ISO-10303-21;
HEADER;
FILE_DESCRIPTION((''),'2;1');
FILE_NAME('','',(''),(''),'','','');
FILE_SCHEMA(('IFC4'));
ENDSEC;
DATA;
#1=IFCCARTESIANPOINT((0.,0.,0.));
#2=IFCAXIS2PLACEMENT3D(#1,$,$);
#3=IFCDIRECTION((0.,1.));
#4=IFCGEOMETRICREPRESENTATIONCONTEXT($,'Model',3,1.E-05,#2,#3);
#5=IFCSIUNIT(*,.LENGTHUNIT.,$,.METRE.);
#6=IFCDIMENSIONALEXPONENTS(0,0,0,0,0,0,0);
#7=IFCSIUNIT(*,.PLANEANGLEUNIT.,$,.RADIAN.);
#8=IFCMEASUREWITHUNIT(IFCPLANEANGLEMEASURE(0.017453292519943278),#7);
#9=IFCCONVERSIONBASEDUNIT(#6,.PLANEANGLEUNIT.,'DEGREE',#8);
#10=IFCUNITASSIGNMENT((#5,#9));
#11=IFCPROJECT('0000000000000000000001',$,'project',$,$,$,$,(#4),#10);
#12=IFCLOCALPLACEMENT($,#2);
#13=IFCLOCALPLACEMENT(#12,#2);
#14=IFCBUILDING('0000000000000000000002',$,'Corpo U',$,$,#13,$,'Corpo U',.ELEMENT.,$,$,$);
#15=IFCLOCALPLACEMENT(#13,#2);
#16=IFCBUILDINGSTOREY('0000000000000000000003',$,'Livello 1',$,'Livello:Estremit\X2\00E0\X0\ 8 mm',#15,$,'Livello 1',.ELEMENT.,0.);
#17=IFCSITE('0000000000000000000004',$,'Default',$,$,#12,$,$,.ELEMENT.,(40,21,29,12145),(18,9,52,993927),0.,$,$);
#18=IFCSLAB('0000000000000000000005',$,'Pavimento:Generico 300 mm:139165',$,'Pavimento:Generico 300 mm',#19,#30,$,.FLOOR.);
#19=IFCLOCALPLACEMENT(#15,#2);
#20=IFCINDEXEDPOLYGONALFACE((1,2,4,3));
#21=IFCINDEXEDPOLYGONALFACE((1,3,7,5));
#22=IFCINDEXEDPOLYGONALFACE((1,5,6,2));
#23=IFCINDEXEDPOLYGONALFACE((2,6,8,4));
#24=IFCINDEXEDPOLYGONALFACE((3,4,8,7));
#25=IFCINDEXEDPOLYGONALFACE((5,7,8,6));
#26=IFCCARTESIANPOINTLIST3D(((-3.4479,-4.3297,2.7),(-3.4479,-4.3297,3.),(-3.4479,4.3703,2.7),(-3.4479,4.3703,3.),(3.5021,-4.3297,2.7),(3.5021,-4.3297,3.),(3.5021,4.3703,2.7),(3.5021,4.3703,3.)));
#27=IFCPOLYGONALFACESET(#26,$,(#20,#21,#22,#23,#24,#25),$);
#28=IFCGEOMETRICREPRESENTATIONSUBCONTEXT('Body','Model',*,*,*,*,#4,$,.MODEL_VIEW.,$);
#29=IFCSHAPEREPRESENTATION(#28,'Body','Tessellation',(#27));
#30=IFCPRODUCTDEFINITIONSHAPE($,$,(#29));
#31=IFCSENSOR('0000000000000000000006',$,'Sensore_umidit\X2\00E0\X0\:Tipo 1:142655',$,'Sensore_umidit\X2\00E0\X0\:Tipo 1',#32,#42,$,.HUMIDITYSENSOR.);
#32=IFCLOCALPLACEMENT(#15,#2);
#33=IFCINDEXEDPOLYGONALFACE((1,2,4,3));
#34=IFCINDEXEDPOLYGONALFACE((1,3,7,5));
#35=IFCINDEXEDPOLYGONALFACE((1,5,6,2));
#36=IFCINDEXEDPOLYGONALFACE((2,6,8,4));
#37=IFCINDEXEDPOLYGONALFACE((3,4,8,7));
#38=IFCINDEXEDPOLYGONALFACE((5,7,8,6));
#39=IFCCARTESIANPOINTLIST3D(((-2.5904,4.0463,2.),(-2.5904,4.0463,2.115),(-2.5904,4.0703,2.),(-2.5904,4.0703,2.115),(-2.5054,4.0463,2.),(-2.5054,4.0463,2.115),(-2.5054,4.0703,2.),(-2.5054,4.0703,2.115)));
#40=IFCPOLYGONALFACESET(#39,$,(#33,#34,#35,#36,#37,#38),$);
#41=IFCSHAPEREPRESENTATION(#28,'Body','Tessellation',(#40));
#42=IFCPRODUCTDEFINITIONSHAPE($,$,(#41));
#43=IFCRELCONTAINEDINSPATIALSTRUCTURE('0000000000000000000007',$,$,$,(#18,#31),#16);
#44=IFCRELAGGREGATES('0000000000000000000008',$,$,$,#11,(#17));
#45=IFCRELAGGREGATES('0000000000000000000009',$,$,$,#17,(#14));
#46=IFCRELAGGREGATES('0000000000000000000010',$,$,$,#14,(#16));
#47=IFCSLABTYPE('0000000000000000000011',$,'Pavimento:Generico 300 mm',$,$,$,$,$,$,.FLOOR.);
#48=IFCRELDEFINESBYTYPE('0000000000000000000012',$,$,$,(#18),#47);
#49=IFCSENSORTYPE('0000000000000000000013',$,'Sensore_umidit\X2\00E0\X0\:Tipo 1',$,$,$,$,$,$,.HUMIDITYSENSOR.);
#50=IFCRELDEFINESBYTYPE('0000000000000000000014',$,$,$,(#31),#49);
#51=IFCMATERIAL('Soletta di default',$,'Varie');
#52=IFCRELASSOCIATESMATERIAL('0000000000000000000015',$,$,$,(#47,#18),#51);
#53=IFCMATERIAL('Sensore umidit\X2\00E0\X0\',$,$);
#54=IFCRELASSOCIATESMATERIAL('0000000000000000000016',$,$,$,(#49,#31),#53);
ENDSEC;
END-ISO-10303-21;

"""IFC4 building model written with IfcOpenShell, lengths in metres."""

from ifc_helpers import new_model, entity, si_unit, converted_unit, direction, frame, origin, place, context, subcontext, project, spatial, indexed_curve, outline, extrude, source, transform, mapped, material, type_object, type_shapes, element, save


model = new_model("IFC4")

# Units and contexts
model_context = context("Model", 3, precision=1e-05, world=origin(), true_north=direction((0.0, 1.0)))
body_context = subcontext(model_context, "Body", "Model", "MODEL_VIEW")
ifc_project = project(units=[si_unit("LENGTHUNIT", "METRE"), converted_unit("PLANEANGLEUNIT", "DEGREE", entity("IfcPlaneAngleMeasure", 0.017453292519943278), si_unit("PLANEANGLEUNIT", "RADIAN"), dimensions=[0, 0, 0, 0, 0, 0, 0])], contexts=[model_context])

# Site, building, storey
site_placement = place(None, origin())
site = spatial("IfcSite", under=ifc_project, at=site_placement, Name="Default", CompositionType="ELEMENT", RefLatitude=(40, 21, 29, 12145), RefLongitude=(18, 9, 52, 993927), RefElevation=0.0)
building_placement = place(site_placement, origin())
building = spatial("IfcBuilding", under=site, at=building_placement, Name="Corpo U", LongName="Corpo U", CompositionType="ELEMENT")
storey_placement = place(building_placement, origin())
storey = spatial("IfcBuildingStorey", under=building, at=storey_placement, Name="Livello 1", ObjectType="Livello:Estremità 8 mm", LongName="Livello 1", CompositionType="ELEMENT", Elevation=0.0)

# Slab
ifc_material_1 = material(Name="Soletta di default", Category="Varie")
slab_type = type_object("IfcSlabType", Name="Pavimento:Generico 300 mm", PredefinedType="FLOOR", material=ifc_material_1)
slab_placement = place(storey_placement, origin())
element("IfcSlab", 1, at=slab_placement, inside=storey, type_object=slab_type, material=ifc_material_1, Name="Pavimento:Generico 300 mm:139165", ObjectType="Pavimento:Generico 300 mm", PredefinedType="FLOOR", context=body_context, shape_type="SweptSolid", body=[
    extrude(outline(indexed_curve([(-4.35, -3.475), (4.35, -3.475), (4.35, 3.475), (-4.35, 3.475), (-4.35, -3.475)], self_intersect=False)), frame((0.0271, 0.0203, 3.0), z_axis=(0.0, 0.0, -1.0), x_axis=(0.0, 1.0, 0.0)), (0.0, 0.0, 1.0), 0.3),
])

# Sensor
ifc_material_2 = material(Name="Sensore umidità")
sensor_type = type_object("IfcSensorType", Name="Sensore_umidità:Tipo 1", PredefinedType="HUMIDITYSENSOR", material=ifc_material_2)
shared_shape = source(origin(), body_context, "Body", "SweptSolid", [
    extrude(outline(indexed_curve([(-0.012, -0.0425), (0.012, -0.0425), (0.012, 0.0425), (-0.012, 0.0425), (-0.012, -0.0425)], self_intersect=False)), frame((1.125, 0.162, 2.0), z_axis=(0.0, 0.0, 1.0), x_axis=(0.0, 1.0, 0.0)), (0.0, 0.0, 1.0), 0.115),
])
type_shapes(sensor_type, [shared_shape])
sensor_placement = place(storey_placement, frame((-1.4229, 4.2203, 0.0), z_axis=(0.0, 0.0, 1.0), x_axis=(-1.0, 0.0, 0.0)))
element("IfcSensor", 2, at=sensor_placement, inside=storey, type_object=sensor_type, material=ifc_material_2, Name="Sensore_umidità:Tipo 1:142655", ObjectType="Sensore_umidità:Tipo 1", PredefinedType="HUMIDITYSENSOR", context=body_context, shape_type="MappedRepresentation", body=[
    mapped(shared_shape, transform((0.0, 0.0, 0.0), scale=1.0)),
])

save(model, "model.ifc")
